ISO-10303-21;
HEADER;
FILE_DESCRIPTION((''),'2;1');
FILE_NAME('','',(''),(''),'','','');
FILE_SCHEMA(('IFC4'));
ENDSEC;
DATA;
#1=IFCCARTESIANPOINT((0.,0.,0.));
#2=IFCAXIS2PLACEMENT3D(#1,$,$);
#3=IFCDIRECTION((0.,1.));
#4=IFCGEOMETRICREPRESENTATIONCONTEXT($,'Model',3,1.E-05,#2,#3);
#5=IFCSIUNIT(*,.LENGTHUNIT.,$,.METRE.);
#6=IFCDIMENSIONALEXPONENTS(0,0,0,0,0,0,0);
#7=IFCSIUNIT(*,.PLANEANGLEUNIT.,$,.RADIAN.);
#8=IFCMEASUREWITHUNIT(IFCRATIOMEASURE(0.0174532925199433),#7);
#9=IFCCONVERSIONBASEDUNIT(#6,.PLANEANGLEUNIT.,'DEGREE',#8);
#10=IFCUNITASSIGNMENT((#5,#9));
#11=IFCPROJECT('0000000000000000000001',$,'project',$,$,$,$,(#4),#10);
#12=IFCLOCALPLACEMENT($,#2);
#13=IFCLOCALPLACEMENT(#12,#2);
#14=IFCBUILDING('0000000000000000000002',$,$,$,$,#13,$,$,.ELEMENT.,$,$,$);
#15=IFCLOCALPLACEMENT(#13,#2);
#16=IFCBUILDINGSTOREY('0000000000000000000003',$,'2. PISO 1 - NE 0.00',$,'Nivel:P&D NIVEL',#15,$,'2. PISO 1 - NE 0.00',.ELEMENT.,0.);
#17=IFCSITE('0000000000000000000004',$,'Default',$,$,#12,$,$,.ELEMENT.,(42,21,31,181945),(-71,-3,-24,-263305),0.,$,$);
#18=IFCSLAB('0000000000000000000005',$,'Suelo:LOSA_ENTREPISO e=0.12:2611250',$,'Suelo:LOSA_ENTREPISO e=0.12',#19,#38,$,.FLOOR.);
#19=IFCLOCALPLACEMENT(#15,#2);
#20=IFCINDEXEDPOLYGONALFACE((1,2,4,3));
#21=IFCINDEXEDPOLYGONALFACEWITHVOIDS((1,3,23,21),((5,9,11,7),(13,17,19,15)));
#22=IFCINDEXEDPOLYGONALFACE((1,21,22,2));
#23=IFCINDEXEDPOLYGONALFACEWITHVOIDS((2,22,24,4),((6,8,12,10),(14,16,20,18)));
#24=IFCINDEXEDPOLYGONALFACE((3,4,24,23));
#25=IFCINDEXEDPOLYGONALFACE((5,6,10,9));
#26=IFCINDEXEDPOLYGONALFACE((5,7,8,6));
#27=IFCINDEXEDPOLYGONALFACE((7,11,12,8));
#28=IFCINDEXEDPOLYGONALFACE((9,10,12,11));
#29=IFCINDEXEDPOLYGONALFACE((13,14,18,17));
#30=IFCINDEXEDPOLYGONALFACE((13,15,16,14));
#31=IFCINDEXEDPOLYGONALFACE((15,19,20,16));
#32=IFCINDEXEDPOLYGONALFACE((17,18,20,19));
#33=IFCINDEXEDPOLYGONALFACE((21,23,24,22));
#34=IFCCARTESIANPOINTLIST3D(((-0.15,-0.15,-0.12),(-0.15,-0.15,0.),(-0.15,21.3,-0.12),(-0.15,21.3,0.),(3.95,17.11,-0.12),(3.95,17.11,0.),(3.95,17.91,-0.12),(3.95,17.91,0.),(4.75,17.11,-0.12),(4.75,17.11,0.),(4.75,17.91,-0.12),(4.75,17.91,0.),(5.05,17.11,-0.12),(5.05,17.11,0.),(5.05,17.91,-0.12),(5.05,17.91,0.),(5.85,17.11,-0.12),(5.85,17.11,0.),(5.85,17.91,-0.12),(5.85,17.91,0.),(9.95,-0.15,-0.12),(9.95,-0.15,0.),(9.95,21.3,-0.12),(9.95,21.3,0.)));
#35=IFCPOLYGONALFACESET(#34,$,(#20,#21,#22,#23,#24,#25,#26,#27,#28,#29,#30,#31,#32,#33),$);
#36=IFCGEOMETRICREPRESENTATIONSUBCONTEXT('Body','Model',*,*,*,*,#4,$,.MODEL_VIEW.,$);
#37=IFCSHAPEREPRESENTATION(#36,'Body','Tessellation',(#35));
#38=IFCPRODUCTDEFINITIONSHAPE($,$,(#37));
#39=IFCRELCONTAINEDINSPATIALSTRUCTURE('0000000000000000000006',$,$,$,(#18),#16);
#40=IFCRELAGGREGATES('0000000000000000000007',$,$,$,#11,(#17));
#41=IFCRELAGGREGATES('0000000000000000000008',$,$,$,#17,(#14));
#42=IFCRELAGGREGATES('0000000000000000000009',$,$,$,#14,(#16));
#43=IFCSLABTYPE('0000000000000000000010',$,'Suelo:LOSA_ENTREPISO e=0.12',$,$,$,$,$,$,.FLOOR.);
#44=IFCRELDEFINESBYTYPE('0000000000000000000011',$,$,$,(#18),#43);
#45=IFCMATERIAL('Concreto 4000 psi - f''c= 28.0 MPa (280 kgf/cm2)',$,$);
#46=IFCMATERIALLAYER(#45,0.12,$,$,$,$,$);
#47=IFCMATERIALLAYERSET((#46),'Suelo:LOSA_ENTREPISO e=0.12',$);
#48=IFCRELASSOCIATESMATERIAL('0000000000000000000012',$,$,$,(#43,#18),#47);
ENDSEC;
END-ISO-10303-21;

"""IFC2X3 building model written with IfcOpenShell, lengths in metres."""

from ifc_helpers import new_model, entity, si_unit, converted_unit, direction, frame, frame_2d, origin, origin_2d_with_axis, place, context, subcontext, project, spatial, rectangle, extrude, material, layer, layer_set, layer_usage, type_object, element, save


model = new_model("IFC2X3")

# Units and contexts
model_context = context("Model", 3, precision=1e-05, world=origin(), true_north=direction((0.0, 1.0)))
body_context = subcontext(model_context, "Body", "Model", "MODEL_VIEW")
ifc_project = project(units=[si_unit("LENGTHUNIT", "METRE"), converted_unit("PLANEANGLEUNIT", "DEGREE", entity("IfcRatioMeasure", 0.0174532925199433), si_unit("PLANEANGLEUNIT", "RADIAN"), dimensions=[0, 0, 0, 0, 0, 0, 0])], contexts=[model_context])

# Site, building, storey
site_placement = place(None, origin())
site = spatial("IfcSite", under=ifc_project, at=site_placement, Name="Default", CompositionType="ELEMENT", RefLatitude=(42, 21, 31, 181945), RefLongitude=(-71, -3, -24, -263305), RefElevation=0.0)
building_placement = place(site_placement, origin())
building = spatial("IfcBuilding", under=site, at=building_placement, CompositionType="ELEMENT")
storey_placement = place(building_placement, origin())
storey = spatial("IfcBuildingStorey", under=building, at=storey_placement, Name="2. PISO 1 - NE 0.00", ObjectType="Nivel:P&D NIVEL", LongName="2. PISO 1 - NE 0.00", CompositionType="ELEMENT", Elevation=0.0)

# Shared definitions
ifc_material = material(Name="Concreto 4000 psi - f'c= 28.0 MPa (280 kgf/cm2)")

# Slab, openings
ifc_layer = layer(ifc_material, 0.12)
ifc_layer_set = layer_set([ifc_layer], Name="Suelo:LOSA_ENTREPISO e=0.12")
ifc_layer_usage = layer_usage(ifc_layer_set, "AXIS3", "POSITIVE", 0.0)
slab_type = type_object("IfcSlabType", Name="Suelo:LOSA_ENTREPISO e=0.12", PredefinedType="FLOOR", material=ifc_layer_set)
slab_placement = place(storey_placement, origin())
slab = element("IfcSlab", 1, at=slab_placement, inside=storey, type_object=slab_type, material=ifc_layer_usage, Name="Suelo:LOSA_ENTREPISO e=0.12:2611250", ObjectType="Suelo:LOSA_ENTREPISO e=0.12", PredefinedType="FLOOR", context=body_context, shape_type="SweptSolid", body=[
    extrude(rectangle(XDim=10.1, YDim=21.45, at=frame_2d((0.0, 0.0), x_axis=(-1.0, 0.0))), frame((4.9, 10.575, 0.0), z_axis=(0.0, 0.0, -1.0), x_axis=(-1.0, 0.0, 0.0)), (0.0, 0.0, 1.0), 0.12),
])
opening_1_placement = place(slab_placement, origin())
element("IfcOpeningElement", 2, at=opening_1_placement, cuts=slab, ObjectType="Opening", context=body_context, shape_type="SweptSolid", body=[
    extrude(rectangle(XDim=0.8, YDim=0.8, at=origin_2d_with_axis()), frame((4.35, 17.51, 0.0), z_axis=(0.0, 0.0, -1.0), x_axis=(0.0, 1.0, 0.0)), (0.0, 0.0, 1.0), 0.12),
])
opening_2_placement = place(slab_placement, origin())
element("IfcOpeningElement", 3, at=opening_2_placement, cuts=slab, ObjectType="Opening", context=body_context, shape_type="SweptSolid", body=[
    extrude(rectangle(XDim=0.8, YDim=0.8, at=origin_2d_with_axis()), frame((5.45, 17.51, 0.0), z_axis=(0.0, 0.0, -1.0), x_axis=(-1.0, 0.0, 0.0)), (0.0, 0.0, 1.0), 0.12),
])

save(model, "model.ifc")
